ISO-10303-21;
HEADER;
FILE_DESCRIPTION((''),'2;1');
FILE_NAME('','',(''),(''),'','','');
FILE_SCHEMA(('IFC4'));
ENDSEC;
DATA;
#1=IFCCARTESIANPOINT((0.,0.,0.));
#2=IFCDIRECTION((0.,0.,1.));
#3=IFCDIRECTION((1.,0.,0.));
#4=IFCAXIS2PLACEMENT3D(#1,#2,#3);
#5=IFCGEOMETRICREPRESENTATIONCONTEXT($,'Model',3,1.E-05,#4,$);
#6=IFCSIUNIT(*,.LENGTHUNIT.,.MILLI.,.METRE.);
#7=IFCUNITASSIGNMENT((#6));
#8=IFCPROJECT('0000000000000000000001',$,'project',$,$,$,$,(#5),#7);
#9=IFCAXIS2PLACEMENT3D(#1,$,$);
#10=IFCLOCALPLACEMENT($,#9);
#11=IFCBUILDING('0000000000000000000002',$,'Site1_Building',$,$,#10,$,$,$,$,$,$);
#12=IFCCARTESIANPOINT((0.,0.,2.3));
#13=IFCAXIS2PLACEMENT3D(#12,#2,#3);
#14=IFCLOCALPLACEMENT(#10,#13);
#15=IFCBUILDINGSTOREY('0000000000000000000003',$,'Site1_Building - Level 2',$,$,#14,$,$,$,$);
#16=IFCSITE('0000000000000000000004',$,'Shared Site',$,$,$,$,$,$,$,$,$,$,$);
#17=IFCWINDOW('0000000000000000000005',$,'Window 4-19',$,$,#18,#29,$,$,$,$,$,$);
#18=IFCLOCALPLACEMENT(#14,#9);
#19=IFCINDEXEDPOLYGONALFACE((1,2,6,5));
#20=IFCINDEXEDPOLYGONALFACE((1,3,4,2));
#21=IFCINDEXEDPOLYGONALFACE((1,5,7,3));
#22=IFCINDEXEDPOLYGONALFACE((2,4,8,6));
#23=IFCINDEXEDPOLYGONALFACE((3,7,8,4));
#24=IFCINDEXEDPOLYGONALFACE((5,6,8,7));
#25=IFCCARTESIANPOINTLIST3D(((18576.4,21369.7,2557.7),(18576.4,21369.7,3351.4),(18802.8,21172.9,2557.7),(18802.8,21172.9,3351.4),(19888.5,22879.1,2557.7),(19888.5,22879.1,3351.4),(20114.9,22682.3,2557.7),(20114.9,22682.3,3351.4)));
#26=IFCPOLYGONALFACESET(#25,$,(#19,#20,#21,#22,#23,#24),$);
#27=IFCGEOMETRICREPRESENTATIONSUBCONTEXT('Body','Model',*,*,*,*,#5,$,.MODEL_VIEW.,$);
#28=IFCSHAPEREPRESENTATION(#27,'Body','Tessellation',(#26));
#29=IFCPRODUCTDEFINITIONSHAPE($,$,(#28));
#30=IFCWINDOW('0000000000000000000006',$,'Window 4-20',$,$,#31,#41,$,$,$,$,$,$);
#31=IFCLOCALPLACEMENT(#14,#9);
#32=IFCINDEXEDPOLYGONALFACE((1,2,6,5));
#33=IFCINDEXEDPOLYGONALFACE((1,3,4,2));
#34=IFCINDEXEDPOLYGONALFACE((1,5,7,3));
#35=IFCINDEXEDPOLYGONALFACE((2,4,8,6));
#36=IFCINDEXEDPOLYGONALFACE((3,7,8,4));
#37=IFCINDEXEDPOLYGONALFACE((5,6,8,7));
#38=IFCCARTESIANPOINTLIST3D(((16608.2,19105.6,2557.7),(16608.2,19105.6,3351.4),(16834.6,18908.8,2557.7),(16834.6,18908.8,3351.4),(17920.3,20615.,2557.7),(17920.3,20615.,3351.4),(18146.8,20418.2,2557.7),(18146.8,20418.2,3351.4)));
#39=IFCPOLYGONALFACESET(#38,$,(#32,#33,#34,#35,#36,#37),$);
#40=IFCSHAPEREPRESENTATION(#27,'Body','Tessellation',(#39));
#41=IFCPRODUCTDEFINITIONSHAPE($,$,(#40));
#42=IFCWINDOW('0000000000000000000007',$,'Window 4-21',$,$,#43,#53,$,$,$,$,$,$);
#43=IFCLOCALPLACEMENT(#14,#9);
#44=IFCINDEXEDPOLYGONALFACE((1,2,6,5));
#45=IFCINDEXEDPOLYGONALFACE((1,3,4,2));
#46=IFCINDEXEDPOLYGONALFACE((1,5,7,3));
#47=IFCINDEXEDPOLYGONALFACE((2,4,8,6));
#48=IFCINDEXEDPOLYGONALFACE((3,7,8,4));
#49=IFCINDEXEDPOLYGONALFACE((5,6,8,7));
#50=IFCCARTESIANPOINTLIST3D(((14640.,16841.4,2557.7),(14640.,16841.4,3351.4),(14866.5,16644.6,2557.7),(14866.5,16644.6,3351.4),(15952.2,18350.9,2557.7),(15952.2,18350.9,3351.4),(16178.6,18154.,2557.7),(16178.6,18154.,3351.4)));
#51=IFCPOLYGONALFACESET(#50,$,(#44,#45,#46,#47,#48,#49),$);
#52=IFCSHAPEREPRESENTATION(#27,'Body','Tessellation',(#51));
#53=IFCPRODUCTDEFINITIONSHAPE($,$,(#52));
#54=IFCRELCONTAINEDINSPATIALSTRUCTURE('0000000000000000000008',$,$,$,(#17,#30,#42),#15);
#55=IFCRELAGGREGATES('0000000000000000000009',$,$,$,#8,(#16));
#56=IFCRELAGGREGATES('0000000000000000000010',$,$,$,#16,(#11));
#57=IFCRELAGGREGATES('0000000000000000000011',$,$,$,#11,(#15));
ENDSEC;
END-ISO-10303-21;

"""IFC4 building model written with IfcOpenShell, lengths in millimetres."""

from ifc_helpers import new_model, si_unit, frame, origin, origin_with_axes, place, context, subcontext, project, spatial, indexed_curve, outline, extrude, element, save


model = new_model("IFC4")

# Units and contexts
model_context = context("Model", 3, precision=1e-05, world=origin_with_axes())
body_context = subcontext(model_context, "Body", "Model", "MODEL_VIEW")
ifc_project = project(units=[si_unit("LENGTHUNIT", "METRE", prefix="MILLI")], contexts=[model_context])

# Site, building, storey
site = spatial("IfcSite", under=ifc_project, Name="Shared Site")
building_placement = place(None, origin())
building = spatial("IfcBuilding", under=site, at=building_placement, Name="Site1_Building")
storey_placement = place(building_placement, frame((0.0, 0.0, 2.3), z_axis=(0.0, 0.0, 1.0), x_axis=(1.0, 0.0, 0.0)))
storey = spatial("IfcBuildingStorey", under=building, at=storey_placement, Name="Site1_Building - Level 2")

# Windows
for number, where, z_axis, x_axis, name in (
    (1, (19888.5, 22879.1, 2557.7), (0.0, 0.0, 1.0), (-0.656059, -0.75471, 0.0), "Window 4-19"),
    (2, (17920.3, 20615.0, 2557.7), (0.0, 0.0, 1.0), (-0.656059, -0.75471, 0.0), "Window 4-20"),
    (3, (15952.2, 18350.9, 2557.7), (0.0, 0.0, 1.0), (-0.656059, -0.75471, 0.0), "Window 4-21"),
):
    element("IfcWindow", number, at=place(storey_placement, frame(where, z_axis=z_axis, x_axis=x_axis)), inside=storey, Name=name, context=body_context, shape_type="SweptSolid", body=[
        extrude(outline(indexed_curve([(0.0, 0.0), (0.0, 300.0), (2000.0, 300.0), (2000.0, 0.0), (0.0, 0.0)], self_intersect=False)), origin_with_axes(), (0.0, 0.0, 1.0), 793.6),
    ])

save(model, "model.ifc")
